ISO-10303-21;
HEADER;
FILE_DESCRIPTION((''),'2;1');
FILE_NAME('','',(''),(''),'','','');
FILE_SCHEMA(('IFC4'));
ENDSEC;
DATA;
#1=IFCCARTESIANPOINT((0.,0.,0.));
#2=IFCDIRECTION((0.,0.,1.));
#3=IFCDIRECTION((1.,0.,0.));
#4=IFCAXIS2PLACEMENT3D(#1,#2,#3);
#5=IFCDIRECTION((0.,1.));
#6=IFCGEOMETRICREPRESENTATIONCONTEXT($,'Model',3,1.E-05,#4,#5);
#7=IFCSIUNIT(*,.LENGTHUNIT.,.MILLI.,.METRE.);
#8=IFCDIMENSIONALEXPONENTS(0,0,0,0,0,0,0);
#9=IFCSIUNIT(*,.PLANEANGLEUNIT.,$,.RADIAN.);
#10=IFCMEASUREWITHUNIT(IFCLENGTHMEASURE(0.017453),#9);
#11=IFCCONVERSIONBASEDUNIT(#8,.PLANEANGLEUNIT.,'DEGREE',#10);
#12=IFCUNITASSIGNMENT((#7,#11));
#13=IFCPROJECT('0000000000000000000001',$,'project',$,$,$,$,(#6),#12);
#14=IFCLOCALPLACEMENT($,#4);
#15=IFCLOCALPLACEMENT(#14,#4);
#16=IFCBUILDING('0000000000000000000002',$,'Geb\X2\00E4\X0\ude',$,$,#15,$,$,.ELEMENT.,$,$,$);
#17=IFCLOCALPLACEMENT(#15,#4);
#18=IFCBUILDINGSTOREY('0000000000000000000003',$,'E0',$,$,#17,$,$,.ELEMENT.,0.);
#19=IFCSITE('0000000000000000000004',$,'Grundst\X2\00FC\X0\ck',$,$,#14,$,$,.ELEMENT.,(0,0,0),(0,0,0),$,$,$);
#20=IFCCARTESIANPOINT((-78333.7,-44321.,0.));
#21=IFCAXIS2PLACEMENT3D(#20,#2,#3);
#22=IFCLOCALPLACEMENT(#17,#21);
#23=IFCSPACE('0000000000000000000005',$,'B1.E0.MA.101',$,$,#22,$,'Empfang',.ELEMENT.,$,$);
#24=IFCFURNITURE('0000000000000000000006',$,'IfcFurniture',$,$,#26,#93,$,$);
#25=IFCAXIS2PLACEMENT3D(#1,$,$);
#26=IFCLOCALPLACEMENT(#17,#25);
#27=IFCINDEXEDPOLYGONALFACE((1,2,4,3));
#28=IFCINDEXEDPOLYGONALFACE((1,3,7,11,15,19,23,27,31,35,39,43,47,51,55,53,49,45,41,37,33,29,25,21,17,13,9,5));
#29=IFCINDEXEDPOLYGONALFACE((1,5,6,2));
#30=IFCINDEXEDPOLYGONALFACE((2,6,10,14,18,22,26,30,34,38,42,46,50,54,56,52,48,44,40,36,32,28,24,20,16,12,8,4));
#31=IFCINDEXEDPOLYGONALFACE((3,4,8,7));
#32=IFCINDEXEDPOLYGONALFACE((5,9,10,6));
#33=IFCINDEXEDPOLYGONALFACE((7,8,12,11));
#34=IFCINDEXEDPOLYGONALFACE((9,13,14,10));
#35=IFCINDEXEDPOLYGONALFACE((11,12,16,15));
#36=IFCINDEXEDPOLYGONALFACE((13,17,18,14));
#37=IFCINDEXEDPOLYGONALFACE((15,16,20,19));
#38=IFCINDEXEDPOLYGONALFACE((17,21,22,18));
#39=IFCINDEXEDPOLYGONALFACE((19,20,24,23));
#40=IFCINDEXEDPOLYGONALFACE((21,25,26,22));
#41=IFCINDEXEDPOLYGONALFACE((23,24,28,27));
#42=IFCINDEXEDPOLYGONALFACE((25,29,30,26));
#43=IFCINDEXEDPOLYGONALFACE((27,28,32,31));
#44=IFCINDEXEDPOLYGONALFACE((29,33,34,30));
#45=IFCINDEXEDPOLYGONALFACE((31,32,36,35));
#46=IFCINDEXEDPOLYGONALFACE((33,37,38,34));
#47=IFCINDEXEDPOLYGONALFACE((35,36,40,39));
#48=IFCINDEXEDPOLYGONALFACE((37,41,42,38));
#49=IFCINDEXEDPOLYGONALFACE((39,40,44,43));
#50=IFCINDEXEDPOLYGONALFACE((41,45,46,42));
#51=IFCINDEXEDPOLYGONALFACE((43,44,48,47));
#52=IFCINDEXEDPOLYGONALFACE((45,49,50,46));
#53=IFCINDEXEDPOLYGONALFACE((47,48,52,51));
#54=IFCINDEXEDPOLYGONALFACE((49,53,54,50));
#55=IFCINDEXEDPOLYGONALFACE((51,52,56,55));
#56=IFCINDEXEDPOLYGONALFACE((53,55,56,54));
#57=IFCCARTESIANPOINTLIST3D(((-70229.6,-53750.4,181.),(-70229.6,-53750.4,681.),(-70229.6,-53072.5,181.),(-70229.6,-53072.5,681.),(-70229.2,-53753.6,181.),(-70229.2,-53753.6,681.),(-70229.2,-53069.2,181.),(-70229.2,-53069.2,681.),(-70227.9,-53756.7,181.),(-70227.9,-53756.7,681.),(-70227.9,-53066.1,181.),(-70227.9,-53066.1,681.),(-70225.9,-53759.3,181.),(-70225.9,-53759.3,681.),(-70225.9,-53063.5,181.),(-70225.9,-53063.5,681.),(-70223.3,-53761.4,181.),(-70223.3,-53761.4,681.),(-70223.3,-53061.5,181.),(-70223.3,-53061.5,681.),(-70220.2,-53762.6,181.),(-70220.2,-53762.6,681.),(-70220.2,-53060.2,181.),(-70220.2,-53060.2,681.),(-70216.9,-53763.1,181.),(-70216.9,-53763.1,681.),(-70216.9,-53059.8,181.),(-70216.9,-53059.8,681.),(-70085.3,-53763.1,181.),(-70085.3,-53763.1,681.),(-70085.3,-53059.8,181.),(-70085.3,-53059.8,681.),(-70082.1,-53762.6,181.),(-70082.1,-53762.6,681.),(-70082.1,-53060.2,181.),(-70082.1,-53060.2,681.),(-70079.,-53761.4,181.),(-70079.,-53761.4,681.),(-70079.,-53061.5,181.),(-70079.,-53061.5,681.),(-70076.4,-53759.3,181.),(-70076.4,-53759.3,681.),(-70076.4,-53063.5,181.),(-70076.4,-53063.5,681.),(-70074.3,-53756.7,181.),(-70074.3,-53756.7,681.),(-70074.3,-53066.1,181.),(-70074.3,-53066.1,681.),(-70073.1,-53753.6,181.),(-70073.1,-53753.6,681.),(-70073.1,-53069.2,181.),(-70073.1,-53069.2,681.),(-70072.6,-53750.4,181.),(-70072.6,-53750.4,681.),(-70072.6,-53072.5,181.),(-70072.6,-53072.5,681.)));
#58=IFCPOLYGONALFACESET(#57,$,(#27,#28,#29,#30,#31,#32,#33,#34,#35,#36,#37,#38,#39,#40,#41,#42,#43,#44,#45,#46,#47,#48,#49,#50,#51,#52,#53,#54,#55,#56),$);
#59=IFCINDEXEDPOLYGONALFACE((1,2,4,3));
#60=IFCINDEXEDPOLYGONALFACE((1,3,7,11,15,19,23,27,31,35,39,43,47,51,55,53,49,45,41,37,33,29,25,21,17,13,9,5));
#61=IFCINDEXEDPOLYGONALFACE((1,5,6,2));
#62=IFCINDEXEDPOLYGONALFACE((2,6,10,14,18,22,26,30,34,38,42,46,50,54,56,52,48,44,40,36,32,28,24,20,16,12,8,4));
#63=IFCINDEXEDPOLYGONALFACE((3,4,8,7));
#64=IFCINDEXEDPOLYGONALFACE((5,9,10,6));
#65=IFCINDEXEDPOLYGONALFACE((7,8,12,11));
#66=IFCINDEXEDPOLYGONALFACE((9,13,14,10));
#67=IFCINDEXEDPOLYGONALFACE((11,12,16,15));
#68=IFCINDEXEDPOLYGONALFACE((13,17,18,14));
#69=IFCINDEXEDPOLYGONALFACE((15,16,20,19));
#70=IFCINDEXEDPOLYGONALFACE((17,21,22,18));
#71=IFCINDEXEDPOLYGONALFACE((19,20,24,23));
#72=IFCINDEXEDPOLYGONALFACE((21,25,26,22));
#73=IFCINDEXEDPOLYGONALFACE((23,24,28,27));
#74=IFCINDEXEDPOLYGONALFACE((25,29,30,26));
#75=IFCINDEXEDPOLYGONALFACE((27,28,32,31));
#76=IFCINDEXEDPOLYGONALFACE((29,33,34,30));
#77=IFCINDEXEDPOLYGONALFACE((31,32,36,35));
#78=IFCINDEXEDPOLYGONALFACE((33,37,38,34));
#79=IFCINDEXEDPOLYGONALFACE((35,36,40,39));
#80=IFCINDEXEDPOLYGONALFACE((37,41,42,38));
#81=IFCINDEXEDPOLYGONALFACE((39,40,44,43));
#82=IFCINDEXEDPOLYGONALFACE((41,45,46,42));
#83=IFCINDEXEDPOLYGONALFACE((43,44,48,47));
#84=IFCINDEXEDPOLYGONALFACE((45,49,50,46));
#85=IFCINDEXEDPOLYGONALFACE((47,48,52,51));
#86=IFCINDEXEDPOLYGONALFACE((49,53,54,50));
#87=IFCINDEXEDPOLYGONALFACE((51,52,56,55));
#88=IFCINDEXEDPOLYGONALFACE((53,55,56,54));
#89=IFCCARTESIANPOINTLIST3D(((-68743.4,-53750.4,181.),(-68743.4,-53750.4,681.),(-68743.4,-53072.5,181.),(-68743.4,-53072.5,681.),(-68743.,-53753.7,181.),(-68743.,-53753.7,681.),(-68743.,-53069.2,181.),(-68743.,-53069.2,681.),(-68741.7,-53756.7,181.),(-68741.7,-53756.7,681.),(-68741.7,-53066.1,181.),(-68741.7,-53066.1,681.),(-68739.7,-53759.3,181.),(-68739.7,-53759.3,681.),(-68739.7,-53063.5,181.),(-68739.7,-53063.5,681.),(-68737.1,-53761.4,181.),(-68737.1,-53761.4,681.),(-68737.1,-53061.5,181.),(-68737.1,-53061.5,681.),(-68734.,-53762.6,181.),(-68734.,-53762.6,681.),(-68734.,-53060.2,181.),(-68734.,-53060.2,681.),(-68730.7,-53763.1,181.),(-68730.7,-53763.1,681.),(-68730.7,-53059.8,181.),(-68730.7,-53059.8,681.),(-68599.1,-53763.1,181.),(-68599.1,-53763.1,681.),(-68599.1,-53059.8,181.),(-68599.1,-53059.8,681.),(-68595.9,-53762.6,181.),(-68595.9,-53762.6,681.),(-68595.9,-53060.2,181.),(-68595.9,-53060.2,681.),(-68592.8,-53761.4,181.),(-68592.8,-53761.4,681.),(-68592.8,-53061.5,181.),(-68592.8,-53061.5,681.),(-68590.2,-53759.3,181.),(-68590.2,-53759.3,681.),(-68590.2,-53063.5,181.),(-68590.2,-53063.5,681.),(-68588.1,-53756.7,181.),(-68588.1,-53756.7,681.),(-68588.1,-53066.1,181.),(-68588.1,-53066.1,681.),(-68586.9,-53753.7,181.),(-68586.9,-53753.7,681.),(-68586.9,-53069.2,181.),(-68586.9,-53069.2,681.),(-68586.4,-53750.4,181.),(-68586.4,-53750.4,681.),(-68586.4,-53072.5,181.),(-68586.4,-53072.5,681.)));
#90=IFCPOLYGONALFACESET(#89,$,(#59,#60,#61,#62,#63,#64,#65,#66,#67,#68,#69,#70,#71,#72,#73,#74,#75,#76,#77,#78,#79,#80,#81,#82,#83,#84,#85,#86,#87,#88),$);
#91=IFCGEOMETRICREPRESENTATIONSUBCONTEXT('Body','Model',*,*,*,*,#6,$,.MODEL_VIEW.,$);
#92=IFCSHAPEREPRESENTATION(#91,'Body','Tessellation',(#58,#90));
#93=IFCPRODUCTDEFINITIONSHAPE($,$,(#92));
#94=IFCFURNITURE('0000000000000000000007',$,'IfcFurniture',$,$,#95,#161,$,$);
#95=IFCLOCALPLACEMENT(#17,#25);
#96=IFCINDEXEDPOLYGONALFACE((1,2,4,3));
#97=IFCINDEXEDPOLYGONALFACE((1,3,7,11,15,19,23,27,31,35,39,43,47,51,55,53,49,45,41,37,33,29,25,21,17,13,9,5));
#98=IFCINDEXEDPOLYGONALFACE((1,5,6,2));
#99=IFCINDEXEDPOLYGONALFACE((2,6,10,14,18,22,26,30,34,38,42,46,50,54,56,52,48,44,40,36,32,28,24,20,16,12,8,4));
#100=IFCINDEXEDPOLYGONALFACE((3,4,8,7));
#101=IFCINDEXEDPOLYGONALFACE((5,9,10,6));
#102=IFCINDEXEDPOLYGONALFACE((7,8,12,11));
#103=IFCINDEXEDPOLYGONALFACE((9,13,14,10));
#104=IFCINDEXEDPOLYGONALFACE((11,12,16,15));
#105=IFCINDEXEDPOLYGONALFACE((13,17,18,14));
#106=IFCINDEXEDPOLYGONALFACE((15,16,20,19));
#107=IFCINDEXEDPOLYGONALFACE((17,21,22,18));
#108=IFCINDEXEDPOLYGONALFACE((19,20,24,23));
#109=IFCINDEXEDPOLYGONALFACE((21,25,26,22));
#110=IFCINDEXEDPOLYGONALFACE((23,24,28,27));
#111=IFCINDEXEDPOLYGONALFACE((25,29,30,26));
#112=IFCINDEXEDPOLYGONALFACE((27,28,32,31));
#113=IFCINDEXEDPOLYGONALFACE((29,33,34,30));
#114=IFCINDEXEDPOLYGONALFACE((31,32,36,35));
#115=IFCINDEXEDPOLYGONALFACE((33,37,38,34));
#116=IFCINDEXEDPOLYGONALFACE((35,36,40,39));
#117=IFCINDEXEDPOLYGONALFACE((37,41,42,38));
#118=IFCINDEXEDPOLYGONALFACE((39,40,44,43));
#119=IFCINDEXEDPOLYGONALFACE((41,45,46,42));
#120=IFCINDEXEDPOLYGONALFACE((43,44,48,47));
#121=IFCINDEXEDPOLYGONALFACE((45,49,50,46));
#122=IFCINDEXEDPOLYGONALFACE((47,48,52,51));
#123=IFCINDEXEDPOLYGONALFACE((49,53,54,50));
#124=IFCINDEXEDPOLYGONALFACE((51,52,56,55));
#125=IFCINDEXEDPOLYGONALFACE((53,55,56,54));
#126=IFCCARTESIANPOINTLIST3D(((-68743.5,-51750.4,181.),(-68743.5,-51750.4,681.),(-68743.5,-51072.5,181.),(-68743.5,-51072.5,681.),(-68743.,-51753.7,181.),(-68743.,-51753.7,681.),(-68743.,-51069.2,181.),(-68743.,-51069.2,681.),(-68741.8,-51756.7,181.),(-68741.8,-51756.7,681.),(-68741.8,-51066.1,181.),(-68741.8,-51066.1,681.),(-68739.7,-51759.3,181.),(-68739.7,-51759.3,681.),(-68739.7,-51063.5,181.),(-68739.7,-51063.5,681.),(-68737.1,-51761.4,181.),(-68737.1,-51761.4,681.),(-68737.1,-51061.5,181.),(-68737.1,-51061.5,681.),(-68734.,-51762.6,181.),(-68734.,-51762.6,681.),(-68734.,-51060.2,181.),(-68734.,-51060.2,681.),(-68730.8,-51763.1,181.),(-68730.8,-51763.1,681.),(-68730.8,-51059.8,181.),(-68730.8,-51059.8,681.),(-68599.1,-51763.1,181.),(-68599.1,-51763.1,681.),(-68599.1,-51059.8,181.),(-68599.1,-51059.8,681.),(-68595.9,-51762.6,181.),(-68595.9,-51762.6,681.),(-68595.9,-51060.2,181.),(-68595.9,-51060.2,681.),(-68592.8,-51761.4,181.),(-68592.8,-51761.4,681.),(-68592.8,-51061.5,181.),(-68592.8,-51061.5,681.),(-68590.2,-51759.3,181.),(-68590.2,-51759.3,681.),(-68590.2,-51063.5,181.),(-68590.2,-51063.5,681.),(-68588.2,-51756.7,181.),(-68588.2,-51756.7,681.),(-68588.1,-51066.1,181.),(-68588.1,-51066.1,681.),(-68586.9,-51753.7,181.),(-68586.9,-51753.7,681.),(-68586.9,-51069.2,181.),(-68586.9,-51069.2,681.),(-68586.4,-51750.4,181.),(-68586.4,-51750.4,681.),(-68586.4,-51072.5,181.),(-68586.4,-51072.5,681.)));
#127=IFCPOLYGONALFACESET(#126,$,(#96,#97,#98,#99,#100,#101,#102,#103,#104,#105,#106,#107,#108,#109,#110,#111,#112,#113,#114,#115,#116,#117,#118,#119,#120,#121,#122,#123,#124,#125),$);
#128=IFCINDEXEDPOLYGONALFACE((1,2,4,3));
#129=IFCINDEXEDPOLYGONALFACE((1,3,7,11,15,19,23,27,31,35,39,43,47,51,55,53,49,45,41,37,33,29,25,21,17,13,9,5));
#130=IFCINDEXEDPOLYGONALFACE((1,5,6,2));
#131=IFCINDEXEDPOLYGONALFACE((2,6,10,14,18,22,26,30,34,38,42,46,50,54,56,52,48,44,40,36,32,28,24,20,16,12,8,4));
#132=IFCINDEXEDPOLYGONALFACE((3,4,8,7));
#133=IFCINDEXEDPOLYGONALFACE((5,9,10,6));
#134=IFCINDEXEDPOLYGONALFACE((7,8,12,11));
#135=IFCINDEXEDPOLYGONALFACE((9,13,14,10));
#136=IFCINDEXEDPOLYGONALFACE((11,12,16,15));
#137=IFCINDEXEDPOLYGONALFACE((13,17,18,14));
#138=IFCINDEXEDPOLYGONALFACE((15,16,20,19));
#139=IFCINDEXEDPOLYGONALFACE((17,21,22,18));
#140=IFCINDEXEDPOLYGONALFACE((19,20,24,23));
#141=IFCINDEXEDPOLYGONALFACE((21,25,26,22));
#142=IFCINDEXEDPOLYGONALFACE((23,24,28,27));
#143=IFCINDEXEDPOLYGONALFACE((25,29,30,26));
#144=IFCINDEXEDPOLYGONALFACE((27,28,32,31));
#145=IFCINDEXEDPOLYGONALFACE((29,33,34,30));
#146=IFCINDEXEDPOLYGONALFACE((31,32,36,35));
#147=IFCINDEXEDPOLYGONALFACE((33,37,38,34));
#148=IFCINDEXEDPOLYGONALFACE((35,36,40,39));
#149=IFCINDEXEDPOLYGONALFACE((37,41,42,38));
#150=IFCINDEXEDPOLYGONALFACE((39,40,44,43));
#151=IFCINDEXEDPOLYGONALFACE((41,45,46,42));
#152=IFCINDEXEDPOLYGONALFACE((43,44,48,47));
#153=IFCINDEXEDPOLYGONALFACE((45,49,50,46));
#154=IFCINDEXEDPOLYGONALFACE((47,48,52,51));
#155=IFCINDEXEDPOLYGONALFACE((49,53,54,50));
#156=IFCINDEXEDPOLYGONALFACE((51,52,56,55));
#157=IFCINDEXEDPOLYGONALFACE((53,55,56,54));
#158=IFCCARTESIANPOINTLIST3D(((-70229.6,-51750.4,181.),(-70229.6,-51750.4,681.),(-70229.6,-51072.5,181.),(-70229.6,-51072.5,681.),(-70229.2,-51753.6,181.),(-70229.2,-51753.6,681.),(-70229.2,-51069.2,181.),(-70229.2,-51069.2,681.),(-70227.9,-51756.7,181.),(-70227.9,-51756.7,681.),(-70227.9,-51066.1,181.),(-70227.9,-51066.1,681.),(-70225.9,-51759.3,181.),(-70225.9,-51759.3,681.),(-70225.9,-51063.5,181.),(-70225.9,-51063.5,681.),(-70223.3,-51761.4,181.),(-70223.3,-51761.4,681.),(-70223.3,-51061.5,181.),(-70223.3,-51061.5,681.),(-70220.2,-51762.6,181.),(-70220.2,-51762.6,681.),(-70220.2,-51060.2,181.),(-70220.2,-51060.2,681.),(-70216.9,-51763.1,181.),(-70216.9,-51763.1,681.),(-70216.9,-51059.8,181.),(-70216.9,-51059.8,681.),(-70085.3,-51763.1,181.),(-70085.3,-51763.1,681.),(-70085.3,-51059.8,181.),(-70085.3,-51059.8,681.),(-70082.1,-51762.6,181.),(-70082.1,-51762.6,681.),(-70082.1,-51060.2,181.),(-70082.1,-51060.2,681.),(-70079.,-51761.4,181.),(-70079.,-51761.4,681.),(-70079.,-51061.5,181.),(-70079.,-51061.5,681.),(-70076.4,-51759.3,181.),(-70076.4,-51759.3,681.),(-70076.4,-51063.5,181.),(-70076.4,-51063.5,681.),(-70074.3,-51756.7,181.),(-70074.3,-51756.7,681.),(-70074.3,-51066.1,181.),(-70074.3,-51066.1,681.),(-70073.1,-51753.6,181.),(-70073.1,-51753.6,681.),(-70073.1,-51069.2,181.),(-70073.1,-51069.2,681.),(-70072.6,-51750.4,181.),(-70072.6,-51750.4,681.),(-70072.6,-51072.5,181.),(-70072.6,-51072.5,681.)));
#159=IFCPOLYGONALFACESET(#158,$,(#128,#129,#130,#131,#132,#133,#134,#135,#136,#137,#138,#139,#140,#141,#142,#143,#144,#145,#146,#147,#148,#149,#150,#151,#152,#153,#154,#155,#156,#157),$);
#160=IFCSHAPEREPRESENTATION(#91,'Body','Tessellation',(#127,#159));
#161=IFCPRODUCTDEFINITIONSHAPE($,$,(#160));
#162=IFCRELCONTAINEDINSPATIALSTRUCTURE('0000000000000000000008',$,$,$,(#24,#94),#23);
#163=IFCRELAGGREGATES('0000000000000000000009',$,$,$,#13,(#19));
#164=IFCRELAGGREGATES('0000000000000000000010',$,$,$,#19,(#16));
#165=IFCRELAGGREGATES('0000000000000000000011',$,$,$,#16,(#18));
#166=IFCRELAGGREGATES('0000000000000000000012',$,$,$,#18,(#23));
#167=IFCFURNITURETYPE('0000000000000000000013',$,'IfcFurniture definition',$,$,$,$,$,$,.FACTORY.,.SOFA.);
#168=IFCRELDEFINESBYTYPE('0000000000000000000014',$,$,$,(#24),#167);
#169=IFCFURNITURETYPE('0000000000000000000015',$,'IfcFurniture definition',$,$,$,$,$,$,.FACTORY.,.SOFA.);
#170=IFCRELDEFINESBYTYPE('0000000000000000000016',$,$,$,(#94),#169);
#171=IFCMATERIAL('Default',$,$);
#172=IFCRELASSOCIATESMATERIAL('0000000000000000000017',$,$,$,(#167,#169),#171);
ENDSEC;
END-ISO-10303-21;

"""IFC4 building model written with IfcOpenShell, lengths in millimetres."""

from ifc_helpers import new_model, entity, si_unit, converted_unit, direction, frame, origin_with_axes, place, context, subcontext, project, spatial, line, arc, indexed_curve, outline, extrude, material, type_object, element, save


model = new_model("IFC4")

# Units and contexts
model_context = context("Model", 3, precision=1e-05, world=origin_with_axes(), true_north=direction((0.0, 1.0)))
body_context = subcontext(model_context, "Body", "Model", "MODEL_VIEW")
ifc_project = project(units=[si_unit("LENGTHUNIT", "METRE", prefix="MILLI"), converted_unit("PLANEANGLEUNIT", "DEGREE", entity("IfcLengthMeasure", 0.017453), si_unit("PLANEANGLEUNIT", "RADIAN"), dimensions=[0, 0, 0, 0, 0, 0, 0])], contexts=[model_context])

# Site, building, storey
site_placement = place(None, origin_with_axes())
site = spatial("IfcSite", under=ifc_project, at=site_placement, Name="Grundstück", CompositionType="ELEMENT", RefLatitude=(0, 0, 0), RefLongitude=(0, 0, 0))
building_placement = place(site_placement, origin_with_axes())
building = spatial("IfcBuilding", under=site, at=building_placement, Name="Gebäude", CompositionType="ELEMENT")
storey_placement = place(building_placement, origin_with_axes())
storey = spatial("IfcBuildingStorey", under=building, at=storey_placement, Name="E0", CompositionType="ELEMENT", Elevation=0.0)

# Shared definitions
space_1_placement = place(storey_placement, frame((-78333.7, -44321.0, 0.0), z_axis=(0.0, 0.0, 1.0), x_axis=(1.0, 0.0, 0.0)))
space_1 = spatial("IfcSpace", under=storey, at=space_1_placement, Name="B1.E0.MA.101", LongName="Empfang", CompositionType="ELEMENT")

# Furniture
ifc_material_1 = material(Name="Default")
furniture_type_1 = type_object("IfcFurnitureType", Name="IfcFurniture definition", AssemblyPlace="FACTORY", PredefinedType="SOFA", material=ifc_material_1)
furniture_1_placement = place(space_1_placement, frame((8925.7, -9090.4, 181.0), z_axis=(0.0, 0.0, 1.0), x_axis=(-1.0, 0.0, 0.0)))
element("IfcFurniture", 1, at=furniture_1_placement, inside=space_1, type_object=furniture_type_1, Name="IfcFurniture", context=body_context, shape_type="SweptSolid", body=[
    extrude(outline(indexed_curve([(808.9, 351.6), (817.9, 347.9), (821.6, 338.9), (821.6, -339.0), (817.9, -347.9), (808.9, -351.7), (677.3, -351.7), (668.3, -347.9), (664.6, -339.0), (664.6, 338.9), (668.3, 347.9), (677.3, 351.6)], segments=[arc(1, 2, 3), line(3, 4), arc(4, 5, 6), line(6, 7), arc(7, 8, 9), line(9, 10), arc(10, 11, 12), line(12, 1)])), origin_with_axes(), (0.0, 0.0, 1.0), 500.0),
    extrude(outline(indexed_curve([(-808.9, 351.7), (-817.9, 347.9), (-821.6, 339.0), (-821.6, -338.9), (-817.9, -347.9), (-808.9, -351.6), (-677.3, -351.6), (-668.3, -347.9), (-664.6, -338.9), (-664.6, 339.0), (-668.3, 347.9), (-677.3, 351.7)], segments=[arc(1, 2, 3), line(3, 4), arc(4, 5, 6), line(6, 7), arc(7, 8, 9), line(9, 10), arc(10, 11, 12), line(12, 1)])), origin_with_axes(), (0.0, 0.0, 1.0), 500.0),
])
furniture_type_2 = type_object("IfcFurnitureType", Name="IfcFurniture definition", AssemblyPlace="FACTORY", PredefinedType="SOFA", material=ifc_material_1)
furniture_2_placement = place(space_1_placement, frame((8925.7, -7090.4, 181.0), z_axis=(0.0, 0.0, 1.0), x_axis=(1.0, 0.0, 0.0)))
element("IfcFurniture", 2, at=furniture_2_placement, inside=space_1, type_object=furniture_type_2, Name="IfcFurniture", context=body_context, shape_type="SweptSolid", body=[
    extrude(outline(indexed_curve([(808.9, 351.6), (817.9, 347.9), (821.6, 338.9), (821.6, -339.0), (817.9, -347.9), (808.9, -351.7), (677.3, -351.7), (668.3, -347.9), (664.6, -339.0), (664.6, 338.9), (668.3, 347.9), (677.3, 351.6)], segments=[arc(1, 2, 3), line(3, 4), arc(4, 5, 6), line(6, 7), arc(7, 8, 9), line(9, 10), arc(10, 11, 12), line(12, 1)])), origin_with_axes(), (0.0, 0.0, 1.0), 500.0),
    extrude(outline(indexed_curve([(-808.9, 351.7), (-817.9, 347.9), (-821.6, 339.0), (-821.6, -338.9), (-817.9, -347.9), (-808.9, -351.6), (-677.3, -351.6), (-668.3, -347.9), (-664.6, -338.9), (-664.6, 339.0), (-668.3, 347.9), (-677.3, 351.7)], segments=[arc(1, 2, 3), line(3, 4), arc(4, 5, 6), line(6, 7), arc(7, 8, 9), line(9, 10), arc(10, 11, 12), line(12, 1)])), origin_with_axes(), (0.0, 0.0, 1.0), 500.0),
])

save(model, "model.ifc")
